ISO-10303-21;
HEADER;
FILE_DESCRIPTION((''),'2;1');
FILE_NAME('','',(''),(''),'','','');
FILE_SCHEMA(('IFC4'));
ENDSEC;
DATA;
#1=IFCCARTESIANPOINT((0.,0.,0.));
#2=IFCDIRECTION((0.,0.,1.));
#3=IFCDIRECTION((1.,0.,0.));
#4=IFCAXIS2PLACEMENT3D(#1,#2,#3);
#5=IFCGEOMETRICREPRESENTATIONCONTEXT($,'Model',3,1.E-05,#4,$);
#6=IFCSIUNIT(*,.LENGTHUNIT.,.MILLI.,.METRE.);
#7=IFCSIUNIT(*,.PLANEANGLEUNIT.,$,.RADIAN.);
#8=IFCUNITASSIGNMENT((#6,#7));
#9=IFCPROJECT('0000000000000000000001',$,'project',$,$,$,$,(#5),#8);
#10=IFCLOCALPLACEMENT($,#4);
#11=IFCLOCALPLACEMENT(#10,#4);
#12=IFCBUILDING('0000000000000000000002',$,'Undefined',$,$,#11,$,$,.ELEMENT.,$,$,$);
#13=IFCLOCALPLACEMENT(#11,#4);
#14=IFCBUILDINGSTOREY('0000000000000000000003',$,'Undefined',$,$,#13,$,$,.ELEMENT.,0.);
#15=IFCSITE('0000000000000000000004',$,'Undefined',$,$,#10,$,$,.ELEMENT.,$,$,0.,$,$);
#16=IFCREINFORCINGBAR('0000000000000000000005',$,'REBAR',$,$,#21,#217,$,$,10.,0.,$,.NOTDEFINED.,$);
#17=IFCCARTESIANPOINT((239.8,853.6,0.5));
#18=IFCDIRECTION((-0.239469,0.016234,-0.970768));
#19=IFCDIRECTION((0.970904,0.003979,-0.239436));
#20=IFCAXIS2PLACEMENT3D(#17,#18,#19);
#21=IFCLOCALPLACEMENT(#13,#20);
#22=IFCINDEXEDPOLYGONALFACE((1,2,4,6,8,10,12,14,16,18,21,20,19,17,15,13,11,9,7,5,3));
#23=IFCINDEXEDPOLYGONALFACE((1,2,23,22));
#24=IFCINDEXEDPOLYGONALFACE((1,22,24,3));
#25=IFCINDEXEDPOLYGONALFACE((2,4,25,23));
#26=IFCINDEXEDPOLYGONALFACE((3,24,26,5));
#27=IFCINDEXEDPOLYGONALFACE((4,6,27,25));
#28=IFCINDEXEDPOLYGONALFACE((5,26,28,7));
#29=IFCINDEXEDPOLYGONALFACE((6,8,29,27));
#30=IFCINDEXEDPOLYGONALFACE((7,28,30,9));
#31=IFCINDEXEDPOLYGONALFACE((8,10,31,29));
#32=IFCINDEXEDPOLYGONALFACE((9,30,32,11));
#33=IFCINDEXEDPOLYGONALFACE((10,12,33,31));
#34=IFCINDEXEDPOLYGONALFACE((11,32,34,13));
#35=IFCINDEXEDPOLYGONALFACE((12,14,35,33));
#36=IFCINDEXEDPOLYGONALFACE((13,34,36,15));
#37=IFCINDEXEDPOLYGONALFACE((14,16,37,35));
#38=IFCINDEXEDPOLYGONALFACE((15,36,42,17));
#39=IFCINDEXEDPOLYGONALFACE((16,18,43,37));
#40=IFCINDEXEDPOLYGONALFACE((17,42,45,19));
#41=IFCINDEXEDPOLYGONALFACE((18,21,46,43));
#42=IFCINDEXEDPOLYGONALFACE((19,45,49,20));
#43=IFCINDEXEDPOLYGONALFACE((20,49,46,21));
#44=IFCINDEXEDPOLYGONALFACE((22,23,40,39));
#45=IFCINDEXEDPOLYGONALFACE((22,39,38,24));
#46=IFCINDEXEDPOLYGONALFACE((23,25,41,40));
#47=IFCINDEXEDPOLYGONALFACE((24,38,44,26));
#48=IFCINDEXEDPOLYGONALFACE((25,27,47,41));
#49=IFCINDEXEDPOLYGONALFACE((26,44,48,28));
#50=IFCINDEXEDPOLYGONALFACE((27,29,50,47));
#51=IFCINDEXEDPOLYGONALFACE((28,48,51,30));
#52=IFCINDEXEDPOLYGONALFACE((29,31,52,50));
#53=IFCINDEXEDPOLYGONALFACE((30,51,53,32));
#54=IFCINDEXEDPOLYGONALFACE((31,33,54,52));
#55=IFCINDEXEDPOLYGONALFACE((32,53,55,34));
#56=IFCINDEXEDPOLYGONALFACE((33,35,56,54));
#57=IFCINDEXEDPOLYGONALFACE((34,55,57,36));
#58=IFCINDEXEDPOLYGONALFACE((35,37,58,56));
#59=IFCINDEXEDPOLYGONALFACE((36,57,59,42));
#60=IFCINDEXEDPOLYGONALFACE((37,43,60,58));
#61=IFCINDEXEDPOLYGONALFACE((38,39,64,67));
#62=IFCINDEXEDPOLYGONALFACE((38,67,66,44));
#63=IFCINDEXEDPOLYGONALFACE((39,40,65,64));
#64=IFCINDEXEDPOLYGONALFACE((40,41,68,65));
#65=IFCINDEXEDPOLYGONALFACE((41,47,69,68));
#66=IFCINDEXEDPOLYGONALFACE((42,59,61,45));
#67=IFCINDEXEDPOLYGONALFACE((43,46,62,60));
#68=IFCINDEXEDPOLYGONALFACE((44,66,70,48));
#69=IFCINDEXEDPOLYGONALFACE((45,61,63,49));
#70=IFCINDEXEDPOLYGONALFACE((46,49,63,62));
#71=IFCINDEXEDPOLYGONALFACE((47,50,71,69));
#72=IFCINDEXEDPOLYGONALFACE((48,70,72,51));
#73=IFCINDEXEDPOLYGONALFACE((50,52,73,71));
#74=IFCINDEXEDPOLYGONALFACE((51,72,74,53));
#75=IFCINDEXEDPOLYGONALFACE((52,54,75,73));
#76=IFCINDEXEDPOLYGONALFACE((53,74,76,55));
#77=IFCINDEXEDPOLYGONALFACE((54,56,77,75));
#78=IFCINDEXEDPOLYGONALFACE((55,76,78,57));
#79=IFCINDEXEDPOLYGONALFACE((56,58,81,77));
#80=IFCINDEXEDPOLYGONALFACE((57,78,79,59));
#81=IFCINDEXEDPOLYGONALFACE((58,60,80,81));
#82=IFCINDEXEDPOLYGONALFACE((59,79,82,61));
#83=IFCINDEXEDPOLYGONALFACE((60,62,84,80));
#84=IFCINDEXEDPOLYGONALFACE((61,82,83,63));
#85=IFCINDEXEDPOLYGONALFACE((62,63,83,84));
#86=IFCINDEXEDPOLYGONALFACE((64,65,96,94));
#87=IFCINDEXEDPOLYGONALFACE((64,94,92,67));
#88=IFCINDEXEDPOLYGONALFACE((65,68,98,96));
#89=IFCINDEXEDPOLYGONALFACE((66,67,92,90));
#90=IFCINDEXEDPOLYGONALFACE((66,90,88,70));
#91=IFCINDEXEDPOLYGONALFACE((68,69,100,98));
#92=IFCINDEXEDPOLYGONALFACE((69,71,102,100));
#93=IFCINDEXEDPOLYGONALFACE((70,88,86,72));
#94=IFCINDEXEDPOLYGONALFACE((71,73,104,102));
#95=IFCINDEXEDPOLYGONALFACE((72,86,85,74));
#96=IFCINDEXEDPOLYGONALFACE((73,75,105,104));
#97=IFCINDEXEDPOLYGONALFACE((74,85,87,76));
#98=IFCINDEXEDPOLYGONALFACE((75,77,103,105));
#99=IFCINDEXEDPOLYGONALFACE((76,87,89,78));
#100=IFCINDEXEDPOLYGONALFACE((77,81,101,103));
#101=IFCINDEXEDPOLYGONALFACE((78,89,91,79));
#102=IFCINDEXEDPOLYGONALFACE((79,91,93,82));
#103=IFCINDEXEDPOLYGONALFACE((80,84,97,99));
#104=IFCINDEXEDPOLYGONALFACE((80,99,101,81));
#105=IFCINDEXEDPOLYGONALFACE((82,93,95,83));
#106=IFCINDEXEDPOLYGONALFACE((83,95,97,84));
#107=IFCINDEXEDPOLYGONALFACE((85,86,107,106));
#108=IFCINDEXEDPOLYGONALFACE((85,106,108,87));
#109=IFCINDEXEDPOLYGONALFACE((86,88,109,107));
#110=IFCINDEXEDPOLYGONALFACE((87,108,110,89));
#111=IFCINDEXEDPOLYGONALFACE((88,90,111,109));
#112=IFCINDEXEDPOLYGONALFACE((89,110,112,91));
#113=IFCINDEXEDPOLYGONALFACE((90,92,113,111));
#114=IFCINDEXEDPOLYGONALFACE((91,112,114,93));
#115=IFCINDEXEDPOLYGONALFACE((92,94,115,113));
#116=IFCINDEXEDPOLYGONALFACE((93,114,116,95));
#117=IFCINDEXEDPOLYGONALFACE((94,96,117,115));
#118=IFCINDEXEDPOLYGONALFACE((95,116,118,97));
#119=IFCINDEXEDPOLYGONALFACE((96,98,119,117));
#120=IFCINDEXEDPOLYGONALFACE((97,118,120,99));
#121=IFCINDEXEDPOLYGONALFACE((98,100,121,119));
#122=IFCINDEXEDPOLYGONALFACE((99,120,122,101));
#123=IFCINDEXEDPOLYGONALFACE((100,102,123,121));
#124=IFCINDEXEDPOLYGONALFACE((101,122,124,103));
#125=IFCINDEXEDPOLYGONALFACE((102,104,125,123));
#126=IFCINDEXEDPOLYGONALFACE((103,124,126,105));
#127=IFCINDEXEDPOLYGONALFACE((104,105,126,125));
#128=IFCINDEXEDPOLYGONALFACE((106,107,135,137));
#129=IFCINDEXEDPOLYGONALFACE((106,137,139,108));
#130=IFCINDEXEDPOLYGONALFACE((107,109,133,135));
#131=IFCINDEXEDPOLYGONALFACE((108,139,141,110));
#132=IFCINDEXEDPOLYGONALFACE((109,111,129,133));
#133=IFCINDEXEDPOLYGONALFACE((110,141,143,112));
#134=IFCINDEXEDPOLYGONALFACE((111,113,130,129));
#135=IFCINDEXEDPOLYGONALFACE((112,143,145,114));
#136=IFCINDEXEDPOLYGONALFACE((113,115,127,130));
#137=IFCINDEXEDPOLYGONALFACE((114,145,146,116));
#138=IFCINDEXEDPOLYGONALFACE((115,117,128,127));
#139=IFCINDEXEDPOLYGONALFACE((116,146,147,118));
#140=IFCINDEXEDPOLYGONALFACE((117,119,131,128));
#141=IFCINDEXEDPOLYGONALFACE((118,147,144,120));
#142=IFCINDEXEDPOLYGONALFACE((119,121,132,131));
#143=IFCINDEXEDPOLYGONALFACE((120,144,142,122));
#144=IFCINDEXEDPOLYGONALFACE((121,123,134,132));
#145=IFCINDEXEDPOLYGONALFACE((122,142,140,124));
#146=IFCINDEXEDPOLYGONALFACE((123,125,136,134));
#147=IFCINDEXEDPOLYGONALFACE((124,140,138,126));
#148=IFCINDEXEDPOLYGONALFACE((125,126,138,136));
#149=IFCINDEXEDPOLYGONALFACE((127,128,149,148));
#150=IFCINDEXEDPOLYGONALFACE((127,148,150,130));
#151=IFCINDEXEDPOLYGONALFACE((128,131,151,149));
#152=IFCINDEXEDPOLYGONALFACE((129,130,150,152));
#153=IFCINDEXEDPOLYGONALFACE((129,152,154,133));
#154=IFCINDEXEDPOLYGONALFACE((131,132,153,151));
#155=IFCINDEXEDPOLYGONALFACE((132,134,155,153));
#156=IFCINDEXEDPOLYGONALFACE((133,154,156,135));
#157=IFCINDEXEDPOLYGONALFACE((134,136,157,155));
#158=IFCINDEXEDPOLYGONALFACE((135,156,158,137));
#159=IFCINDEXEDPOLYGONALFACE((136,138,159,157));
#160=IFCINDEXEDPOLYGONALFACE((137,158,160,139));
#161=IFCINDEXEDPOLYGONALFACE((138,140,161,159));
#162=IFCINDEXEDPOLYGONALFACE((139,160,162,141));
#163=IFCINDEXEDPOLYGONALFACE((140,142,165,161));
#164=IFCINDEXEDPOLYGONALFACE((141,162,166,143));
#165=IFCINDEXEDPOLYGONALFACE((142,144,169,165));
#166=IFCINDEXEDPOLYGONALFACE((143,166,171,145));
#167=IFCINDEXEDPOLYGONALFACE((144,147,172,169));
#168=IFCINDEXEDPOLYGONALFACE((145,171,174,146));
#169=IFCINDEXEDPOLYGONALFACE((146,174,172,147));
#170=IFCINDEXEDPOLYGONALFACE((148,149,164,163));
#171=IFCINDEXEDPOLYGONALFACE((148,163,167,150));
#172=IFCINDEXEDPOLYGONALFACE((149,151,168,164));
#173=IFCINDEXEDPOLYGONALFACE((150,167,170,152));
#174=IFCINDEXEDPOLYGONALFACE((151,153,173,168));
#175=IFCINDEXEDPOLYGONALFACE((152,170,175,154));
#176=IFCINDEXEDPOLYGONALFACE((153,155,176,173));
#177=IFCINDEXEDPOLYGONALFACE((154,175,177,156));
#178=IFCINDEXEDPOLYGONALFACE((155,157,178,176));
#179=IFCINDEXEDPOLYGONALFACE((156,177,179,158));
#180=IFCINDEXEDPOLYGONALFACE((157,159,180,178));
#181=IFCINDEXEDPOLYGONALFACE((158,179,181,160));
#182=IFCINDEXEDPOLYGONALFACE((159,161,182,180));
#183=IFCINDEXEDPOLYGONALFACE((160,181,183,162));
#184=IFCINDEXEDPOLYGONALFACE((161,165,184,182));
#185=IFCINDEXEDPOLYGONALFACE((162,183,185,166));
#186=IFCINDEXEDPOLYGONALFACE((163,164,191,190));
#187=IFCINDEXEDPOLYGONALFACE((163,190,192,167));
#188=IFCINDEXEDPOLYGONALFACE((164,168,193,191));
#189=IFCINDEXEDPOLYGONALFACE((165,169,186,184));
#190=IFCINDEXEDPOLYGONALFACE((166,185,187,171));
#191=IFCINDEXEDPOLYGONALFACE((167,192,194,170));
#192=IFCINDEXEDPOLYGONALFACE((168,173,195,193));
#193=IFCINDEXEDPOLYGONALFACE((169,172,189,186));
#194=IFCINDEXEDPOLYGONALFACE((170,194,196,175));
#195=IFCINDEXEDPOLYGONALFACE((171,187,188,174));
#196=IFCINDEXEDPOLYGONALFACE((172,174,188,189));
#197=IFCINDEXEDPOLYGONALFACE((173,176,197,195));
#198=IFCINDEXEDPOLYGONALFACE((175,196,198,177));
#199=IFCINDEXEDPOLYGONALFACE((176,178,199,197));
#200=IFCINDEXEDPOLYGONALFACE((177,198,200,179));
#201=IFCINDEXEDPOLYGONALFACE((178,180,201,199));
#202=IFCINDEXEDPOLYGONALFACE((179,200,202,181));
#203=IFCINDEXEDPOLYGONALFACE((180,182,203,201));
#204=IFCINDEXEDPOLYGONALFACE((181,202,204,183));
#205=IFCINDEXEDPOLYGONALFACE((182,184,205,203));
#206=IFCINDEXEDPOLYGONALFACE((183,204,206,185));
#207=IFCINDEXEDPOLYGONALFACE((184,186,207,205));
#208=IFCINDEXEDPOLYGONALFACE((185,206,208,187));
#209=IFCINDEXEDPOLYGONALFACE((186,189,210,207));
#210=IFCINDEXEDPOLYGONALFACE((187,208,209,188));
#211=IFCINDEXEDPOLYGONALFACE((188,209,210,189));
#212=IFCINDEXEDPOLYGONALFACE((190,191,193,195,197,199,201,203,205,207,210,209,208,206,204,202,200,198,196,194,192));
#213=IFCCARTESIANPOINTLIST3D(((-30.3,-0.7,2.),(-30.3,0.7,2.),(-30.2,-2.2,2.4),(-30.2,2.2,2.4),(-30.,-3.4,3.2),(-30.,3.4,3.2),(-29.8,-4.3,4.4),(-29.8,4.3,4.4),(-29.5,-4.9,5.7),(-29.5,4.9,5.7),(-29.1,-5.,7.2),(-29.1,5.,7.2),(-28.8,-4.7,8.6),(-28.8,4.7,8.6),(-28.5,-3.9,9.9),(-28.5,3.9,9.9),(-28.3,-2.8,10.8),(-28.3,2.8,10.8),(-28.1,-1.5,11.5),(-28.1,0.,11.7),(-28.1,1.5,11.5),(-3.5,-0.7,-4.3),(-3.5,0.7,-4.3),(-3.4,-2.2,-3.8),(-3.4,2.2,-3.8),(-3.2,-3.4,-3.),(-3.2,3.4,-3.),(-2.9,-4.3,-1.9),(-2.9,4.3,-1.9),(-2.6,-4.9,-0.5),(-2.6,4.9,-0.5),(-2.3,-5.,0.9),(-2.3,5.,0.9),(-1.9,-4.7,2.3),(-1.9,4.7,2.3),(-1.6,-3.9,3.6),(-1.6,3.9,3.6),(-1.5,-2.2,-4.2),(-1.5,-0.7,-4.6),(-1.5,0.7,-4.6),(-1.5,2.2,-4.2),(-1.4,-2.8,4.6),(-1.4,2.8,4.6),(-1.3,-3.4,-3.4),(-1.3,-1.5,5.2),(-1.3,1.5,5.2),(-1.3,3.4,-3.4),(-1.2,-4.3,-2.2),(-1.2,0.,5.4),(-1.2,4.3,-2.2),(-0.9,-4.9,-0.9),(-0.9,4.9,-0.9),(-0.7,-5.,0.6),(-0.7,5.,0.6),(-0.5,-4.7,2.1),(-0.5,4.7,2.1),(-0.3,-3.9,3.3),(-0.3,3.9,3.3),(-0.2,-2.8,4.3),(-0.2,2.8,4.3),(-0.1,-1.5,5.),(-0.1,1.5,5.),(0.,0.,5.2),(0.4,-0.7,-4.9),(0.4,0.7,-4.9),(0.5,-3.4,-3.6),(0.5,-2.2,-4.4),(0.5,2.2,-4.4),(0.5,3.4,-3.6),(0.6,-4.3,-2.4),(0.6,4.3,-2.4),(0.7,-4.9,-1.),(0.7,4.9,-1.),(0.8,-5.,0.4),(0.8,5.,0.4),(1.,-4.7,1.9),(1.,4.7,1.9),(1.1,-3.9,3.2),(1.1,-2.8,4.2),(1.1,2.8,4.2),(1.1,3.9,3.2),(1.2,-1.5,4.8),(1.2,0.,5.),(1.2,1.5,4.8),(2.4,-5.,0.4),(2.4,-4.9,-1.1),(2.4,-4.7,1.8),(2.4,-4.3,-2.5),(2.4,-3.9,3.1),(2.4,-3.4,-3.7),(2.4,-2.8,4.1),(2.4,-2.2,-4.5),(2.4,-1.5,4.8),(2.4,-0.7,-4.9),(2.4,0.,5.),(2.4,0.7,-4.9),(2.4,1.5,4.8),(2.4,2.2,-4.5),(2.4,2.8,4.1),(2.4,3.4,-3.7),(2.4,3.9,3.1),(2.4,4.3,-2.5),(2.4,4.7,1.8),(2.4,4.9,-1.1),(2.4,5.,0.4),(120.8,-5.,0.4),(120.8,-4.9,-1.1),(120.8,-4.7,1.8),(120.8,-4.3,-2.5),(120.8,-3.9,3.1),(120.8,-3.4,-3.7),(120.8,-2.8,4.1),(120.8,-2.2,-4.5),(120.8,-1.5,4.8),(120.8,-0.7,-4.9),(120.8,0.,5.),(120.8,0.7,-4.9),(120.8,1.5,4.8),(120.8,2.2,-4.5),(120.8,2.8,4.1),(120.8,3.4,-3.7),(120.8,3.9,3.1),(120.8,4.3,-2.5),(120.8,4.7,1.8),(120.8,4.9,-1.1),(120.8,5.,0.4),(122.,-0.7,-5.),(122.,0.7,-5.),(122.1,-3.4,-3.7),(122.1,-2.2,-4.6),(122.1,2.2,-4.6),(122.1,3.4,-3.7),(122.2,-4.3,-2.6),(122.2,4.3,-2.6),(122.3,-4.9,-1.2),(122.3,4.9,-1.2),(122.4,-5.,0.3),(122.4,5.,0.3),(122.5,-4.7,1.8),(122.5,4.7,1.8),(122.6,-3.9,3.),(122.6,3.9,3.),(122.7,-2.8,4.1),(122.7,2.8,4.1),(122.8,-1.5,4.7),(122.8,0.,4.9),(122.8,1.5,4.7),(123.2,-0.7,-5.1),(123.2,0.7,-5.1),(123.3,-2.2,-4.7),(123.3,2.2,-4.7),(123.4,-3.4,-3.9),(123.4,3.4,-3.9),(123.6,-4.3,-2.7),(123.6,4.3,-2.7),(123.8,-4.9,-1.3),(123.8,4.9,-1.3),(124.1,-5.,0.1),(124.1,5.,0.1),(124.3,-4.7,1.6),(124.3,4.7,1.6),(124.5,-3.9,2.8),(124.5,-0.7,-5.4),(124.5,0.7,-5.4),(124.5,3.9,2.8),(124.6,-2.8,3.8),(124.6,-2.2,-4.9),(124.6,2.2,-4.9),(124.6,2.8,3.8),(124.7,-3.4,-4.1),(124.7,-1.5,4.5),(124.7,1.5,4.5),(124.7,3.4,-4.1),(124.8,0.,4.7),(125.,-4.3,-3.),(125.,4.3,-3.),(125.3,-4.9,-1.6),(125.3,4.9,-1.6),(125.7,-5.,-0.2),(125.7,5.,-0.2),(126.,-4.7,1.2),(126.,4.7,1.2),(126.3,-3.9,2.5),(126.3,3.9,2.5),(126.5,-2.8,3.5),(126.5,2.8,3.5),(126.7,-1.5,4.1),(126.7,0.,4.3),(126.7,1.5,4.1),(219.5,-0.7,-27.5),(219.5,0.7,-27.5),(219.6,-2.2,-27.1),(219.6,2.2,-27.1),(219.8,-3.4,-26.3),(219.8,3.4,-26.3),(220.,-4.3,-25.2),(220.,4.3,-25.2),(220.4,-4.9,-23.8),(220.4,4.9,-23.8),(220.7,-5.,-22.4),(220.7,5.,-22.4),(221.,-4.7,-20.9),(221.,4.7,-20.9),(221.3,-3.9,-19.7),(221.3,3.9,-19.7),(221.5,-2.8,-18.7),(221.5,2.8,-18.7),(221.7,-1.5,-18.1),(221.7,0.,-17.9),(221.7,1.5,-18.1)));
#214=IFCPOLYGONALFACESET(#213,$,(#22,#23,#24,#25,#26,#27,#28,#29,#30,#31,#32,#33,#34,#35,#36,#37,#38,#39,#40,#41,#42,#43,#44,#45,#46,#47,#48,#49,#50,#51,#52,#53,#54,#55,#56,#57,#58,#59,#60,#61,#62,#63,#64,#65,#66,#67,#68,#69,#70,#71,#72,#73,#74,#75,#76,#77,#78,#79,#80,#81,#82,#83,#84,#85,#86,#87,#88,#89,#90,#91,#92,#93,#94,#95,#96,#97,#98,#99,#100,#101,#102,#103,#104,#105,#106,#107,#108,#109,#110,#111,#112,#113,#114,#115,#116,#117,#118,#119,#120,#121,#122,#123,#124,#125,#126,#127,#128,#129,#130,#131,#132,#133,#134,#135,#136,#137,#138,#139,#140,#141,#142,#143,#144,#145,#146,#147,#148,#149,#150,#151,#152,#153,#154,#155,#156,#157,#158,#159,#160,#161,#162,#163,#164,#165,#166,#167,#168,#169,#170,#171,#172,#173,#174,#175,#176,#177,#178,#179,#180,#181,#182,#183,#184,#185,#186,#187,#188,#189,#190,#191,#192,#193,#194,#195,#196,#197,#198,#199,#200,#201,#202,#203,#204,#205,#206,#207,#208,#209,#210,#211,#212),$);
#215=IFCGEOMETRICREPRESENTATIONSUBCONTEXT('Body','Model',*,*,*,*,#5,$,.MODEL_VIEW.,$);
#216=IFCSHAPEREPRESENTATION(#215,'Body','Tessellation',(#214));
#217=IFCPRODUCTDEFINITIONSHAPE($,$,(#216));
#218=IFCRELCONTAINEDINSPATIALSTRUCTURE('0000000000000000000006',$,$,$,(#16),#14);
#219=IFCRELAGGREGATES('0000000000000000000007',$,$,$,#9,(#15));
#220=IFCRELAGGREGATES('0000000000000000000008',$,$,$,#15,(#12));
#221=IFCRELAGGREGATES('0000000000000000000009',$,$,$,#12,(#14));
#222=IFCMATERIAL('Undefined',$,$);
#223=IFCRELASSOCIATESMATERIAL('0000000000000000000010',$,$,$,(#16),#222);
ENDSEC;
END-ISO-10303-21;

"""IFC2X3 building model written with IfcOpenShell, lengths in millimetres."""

from ifc_helpers import new_model, entity, si_unit, frame, origin_with_axes, place, context, subcontext, project, spatial, source, transform, mapped, material, element, save


model = new_model("IFC2X3")

# Units and contexts
model_context = context("Model", 3, precision=1e-05, world=origin_with_axes())
body_context = subcontext(model_context, "Body", "Model", "MODEL_VIEW")
ifc_project = project(units=[si_unit("LENGTHUNIT", "METRE", prefix="MILLI"), si_unit("PLANEANGLEUNIT", "RADIAN")], contexts=[model_context])

# Site, building, storey
site_placement = place(None, origin_with_axes())
site = spatial("IfcSite", under=ifc_project, at=site_placement, Name="Undefined", CompositionType="ELEMENT", RefElevation=0.0)
building_placement = place(site_placement, origin_with_axes())
building = spatial("IfcBuilding", under=site, at=building_placement, Name="Undefined", CompositionType="ELEMENT")
storey_placement = place(building_placement, origin_with_axes())
storey = spatial("IfcBuildingStorey", under=building, at=storey_placement, Name="Undefined", CompositionType="ELEMENT", Elevation=0.0)

# Reinforcing bar
ifc_material_1 = material(Name="Undefined")
ifc_direction_1 = entity("IfcDirection", [0.973841, 0.0, -0.22723])
shared_shape_1 = source(origin_with_axes(), body_context, "Body", "AdvancedSweptSolid", [
    entity("IfcSweptDiskSolid", entity("IfcCompositeCurve", [entity("IfcCompositeCurveSegment", "CONTINUOUS", True, entity("IfcTrimmedCurve", entity("IfcLine", entity("IfcCartesianPoint", [0.0, 0.0, 0.0]), entity("IfcVector", ifc_direction_1, 1.0)), [entity("IfcParameterValue", 0.0)], [entity("IfcParameterValue", 27.582469)], True, "PARAMETER")), entity("IfcCompositeCurveSegment", "CONTINUOUS", True, entity("IfcTrimmedCurve", entity("IfcCircle", entity("IfcAxis2Placement3D", entity("IfcCartesianPoint", [31.6, 0.0, 14.2]), entity("IfcDirection", [0.0, -1.0, 0.0]), entity("IfcDirection", [-0.22723, 0.0, -0.973841])), 21.0), [entity("IfcParameterValue", 0.0)], [entity("IfcParameterValue", 0.229232)], True, "PARAMETER")), entity("IfcCompositeCurveSegment", "CONTINUOUS", True, entity("IfcTrimmedCurve", entity("IfcLine", entity("IfcCartesianPoint", [31.6, 0.0, -6.8]), entity("IfcVector", entity("IfcDirection", [1.0, 0.0, 0.0]), 1.0)), [entity("IfcParameterValue", 0.0)], [entity("IfcParameterValue", 118.388313)], True, "PARAMETER")), entity("IfcCompositeCurveSegment", "CONTINUOUS", True, entity("IfcTrimmedCurve", entity("IfcCircle", entity("IfcAxis2Placement3D", entity("IfcCartesianPoint", [150.0, 0.0, -27.8]), entity("IfcDirection", [0.0, 1.0, 0.0]), entity("IfcDirection", [0.0, 0.0, 1.0])), 21.0), [entity("IfcParameterValue", 0.0)], [entity("IfcParameterValue", 0.229232)], True, "PARAMETER")), entity("IfcCompositeCurveSegment", "DISCONTINUOUS", True, entity("IfcTrimmedCurve", entity("IfcLine", entity("IfcCartesianPoint", [154.8, 0.0, -7.4]), entity("IfcVector", ifc_direction_1, 1.0)), [entity("IfcParameterValue", 0.0)], [entity("IfcParameterValue", 97.582469)], True, "PARAMETER"))], False), 5.0, None, 0.0, 244.0),
])
reinforcing_bar_1_placement = place(storey_placement, frame((239.8, 853.6, 0.5), z_axis=(-0.239469, 0.016234, -0.970768), x_axis=(0.970904, 0.003979, -0.239436)))
element("IfcReinforcingBar", 1, at=reinforcing_bar_1_placement, inside=storey, material=ifc_material_1, Name="REBAR", BarRole="NOTDEFINED", CrossSectionArea=0.0, NominalDiameter=10.0, context=body_context, shape_type="MappedRepresentation", body=[
    mapped(shared_shape_1, transform((-29.2, 0.0, 6.8))),
])

save(model, "model.ifc")
